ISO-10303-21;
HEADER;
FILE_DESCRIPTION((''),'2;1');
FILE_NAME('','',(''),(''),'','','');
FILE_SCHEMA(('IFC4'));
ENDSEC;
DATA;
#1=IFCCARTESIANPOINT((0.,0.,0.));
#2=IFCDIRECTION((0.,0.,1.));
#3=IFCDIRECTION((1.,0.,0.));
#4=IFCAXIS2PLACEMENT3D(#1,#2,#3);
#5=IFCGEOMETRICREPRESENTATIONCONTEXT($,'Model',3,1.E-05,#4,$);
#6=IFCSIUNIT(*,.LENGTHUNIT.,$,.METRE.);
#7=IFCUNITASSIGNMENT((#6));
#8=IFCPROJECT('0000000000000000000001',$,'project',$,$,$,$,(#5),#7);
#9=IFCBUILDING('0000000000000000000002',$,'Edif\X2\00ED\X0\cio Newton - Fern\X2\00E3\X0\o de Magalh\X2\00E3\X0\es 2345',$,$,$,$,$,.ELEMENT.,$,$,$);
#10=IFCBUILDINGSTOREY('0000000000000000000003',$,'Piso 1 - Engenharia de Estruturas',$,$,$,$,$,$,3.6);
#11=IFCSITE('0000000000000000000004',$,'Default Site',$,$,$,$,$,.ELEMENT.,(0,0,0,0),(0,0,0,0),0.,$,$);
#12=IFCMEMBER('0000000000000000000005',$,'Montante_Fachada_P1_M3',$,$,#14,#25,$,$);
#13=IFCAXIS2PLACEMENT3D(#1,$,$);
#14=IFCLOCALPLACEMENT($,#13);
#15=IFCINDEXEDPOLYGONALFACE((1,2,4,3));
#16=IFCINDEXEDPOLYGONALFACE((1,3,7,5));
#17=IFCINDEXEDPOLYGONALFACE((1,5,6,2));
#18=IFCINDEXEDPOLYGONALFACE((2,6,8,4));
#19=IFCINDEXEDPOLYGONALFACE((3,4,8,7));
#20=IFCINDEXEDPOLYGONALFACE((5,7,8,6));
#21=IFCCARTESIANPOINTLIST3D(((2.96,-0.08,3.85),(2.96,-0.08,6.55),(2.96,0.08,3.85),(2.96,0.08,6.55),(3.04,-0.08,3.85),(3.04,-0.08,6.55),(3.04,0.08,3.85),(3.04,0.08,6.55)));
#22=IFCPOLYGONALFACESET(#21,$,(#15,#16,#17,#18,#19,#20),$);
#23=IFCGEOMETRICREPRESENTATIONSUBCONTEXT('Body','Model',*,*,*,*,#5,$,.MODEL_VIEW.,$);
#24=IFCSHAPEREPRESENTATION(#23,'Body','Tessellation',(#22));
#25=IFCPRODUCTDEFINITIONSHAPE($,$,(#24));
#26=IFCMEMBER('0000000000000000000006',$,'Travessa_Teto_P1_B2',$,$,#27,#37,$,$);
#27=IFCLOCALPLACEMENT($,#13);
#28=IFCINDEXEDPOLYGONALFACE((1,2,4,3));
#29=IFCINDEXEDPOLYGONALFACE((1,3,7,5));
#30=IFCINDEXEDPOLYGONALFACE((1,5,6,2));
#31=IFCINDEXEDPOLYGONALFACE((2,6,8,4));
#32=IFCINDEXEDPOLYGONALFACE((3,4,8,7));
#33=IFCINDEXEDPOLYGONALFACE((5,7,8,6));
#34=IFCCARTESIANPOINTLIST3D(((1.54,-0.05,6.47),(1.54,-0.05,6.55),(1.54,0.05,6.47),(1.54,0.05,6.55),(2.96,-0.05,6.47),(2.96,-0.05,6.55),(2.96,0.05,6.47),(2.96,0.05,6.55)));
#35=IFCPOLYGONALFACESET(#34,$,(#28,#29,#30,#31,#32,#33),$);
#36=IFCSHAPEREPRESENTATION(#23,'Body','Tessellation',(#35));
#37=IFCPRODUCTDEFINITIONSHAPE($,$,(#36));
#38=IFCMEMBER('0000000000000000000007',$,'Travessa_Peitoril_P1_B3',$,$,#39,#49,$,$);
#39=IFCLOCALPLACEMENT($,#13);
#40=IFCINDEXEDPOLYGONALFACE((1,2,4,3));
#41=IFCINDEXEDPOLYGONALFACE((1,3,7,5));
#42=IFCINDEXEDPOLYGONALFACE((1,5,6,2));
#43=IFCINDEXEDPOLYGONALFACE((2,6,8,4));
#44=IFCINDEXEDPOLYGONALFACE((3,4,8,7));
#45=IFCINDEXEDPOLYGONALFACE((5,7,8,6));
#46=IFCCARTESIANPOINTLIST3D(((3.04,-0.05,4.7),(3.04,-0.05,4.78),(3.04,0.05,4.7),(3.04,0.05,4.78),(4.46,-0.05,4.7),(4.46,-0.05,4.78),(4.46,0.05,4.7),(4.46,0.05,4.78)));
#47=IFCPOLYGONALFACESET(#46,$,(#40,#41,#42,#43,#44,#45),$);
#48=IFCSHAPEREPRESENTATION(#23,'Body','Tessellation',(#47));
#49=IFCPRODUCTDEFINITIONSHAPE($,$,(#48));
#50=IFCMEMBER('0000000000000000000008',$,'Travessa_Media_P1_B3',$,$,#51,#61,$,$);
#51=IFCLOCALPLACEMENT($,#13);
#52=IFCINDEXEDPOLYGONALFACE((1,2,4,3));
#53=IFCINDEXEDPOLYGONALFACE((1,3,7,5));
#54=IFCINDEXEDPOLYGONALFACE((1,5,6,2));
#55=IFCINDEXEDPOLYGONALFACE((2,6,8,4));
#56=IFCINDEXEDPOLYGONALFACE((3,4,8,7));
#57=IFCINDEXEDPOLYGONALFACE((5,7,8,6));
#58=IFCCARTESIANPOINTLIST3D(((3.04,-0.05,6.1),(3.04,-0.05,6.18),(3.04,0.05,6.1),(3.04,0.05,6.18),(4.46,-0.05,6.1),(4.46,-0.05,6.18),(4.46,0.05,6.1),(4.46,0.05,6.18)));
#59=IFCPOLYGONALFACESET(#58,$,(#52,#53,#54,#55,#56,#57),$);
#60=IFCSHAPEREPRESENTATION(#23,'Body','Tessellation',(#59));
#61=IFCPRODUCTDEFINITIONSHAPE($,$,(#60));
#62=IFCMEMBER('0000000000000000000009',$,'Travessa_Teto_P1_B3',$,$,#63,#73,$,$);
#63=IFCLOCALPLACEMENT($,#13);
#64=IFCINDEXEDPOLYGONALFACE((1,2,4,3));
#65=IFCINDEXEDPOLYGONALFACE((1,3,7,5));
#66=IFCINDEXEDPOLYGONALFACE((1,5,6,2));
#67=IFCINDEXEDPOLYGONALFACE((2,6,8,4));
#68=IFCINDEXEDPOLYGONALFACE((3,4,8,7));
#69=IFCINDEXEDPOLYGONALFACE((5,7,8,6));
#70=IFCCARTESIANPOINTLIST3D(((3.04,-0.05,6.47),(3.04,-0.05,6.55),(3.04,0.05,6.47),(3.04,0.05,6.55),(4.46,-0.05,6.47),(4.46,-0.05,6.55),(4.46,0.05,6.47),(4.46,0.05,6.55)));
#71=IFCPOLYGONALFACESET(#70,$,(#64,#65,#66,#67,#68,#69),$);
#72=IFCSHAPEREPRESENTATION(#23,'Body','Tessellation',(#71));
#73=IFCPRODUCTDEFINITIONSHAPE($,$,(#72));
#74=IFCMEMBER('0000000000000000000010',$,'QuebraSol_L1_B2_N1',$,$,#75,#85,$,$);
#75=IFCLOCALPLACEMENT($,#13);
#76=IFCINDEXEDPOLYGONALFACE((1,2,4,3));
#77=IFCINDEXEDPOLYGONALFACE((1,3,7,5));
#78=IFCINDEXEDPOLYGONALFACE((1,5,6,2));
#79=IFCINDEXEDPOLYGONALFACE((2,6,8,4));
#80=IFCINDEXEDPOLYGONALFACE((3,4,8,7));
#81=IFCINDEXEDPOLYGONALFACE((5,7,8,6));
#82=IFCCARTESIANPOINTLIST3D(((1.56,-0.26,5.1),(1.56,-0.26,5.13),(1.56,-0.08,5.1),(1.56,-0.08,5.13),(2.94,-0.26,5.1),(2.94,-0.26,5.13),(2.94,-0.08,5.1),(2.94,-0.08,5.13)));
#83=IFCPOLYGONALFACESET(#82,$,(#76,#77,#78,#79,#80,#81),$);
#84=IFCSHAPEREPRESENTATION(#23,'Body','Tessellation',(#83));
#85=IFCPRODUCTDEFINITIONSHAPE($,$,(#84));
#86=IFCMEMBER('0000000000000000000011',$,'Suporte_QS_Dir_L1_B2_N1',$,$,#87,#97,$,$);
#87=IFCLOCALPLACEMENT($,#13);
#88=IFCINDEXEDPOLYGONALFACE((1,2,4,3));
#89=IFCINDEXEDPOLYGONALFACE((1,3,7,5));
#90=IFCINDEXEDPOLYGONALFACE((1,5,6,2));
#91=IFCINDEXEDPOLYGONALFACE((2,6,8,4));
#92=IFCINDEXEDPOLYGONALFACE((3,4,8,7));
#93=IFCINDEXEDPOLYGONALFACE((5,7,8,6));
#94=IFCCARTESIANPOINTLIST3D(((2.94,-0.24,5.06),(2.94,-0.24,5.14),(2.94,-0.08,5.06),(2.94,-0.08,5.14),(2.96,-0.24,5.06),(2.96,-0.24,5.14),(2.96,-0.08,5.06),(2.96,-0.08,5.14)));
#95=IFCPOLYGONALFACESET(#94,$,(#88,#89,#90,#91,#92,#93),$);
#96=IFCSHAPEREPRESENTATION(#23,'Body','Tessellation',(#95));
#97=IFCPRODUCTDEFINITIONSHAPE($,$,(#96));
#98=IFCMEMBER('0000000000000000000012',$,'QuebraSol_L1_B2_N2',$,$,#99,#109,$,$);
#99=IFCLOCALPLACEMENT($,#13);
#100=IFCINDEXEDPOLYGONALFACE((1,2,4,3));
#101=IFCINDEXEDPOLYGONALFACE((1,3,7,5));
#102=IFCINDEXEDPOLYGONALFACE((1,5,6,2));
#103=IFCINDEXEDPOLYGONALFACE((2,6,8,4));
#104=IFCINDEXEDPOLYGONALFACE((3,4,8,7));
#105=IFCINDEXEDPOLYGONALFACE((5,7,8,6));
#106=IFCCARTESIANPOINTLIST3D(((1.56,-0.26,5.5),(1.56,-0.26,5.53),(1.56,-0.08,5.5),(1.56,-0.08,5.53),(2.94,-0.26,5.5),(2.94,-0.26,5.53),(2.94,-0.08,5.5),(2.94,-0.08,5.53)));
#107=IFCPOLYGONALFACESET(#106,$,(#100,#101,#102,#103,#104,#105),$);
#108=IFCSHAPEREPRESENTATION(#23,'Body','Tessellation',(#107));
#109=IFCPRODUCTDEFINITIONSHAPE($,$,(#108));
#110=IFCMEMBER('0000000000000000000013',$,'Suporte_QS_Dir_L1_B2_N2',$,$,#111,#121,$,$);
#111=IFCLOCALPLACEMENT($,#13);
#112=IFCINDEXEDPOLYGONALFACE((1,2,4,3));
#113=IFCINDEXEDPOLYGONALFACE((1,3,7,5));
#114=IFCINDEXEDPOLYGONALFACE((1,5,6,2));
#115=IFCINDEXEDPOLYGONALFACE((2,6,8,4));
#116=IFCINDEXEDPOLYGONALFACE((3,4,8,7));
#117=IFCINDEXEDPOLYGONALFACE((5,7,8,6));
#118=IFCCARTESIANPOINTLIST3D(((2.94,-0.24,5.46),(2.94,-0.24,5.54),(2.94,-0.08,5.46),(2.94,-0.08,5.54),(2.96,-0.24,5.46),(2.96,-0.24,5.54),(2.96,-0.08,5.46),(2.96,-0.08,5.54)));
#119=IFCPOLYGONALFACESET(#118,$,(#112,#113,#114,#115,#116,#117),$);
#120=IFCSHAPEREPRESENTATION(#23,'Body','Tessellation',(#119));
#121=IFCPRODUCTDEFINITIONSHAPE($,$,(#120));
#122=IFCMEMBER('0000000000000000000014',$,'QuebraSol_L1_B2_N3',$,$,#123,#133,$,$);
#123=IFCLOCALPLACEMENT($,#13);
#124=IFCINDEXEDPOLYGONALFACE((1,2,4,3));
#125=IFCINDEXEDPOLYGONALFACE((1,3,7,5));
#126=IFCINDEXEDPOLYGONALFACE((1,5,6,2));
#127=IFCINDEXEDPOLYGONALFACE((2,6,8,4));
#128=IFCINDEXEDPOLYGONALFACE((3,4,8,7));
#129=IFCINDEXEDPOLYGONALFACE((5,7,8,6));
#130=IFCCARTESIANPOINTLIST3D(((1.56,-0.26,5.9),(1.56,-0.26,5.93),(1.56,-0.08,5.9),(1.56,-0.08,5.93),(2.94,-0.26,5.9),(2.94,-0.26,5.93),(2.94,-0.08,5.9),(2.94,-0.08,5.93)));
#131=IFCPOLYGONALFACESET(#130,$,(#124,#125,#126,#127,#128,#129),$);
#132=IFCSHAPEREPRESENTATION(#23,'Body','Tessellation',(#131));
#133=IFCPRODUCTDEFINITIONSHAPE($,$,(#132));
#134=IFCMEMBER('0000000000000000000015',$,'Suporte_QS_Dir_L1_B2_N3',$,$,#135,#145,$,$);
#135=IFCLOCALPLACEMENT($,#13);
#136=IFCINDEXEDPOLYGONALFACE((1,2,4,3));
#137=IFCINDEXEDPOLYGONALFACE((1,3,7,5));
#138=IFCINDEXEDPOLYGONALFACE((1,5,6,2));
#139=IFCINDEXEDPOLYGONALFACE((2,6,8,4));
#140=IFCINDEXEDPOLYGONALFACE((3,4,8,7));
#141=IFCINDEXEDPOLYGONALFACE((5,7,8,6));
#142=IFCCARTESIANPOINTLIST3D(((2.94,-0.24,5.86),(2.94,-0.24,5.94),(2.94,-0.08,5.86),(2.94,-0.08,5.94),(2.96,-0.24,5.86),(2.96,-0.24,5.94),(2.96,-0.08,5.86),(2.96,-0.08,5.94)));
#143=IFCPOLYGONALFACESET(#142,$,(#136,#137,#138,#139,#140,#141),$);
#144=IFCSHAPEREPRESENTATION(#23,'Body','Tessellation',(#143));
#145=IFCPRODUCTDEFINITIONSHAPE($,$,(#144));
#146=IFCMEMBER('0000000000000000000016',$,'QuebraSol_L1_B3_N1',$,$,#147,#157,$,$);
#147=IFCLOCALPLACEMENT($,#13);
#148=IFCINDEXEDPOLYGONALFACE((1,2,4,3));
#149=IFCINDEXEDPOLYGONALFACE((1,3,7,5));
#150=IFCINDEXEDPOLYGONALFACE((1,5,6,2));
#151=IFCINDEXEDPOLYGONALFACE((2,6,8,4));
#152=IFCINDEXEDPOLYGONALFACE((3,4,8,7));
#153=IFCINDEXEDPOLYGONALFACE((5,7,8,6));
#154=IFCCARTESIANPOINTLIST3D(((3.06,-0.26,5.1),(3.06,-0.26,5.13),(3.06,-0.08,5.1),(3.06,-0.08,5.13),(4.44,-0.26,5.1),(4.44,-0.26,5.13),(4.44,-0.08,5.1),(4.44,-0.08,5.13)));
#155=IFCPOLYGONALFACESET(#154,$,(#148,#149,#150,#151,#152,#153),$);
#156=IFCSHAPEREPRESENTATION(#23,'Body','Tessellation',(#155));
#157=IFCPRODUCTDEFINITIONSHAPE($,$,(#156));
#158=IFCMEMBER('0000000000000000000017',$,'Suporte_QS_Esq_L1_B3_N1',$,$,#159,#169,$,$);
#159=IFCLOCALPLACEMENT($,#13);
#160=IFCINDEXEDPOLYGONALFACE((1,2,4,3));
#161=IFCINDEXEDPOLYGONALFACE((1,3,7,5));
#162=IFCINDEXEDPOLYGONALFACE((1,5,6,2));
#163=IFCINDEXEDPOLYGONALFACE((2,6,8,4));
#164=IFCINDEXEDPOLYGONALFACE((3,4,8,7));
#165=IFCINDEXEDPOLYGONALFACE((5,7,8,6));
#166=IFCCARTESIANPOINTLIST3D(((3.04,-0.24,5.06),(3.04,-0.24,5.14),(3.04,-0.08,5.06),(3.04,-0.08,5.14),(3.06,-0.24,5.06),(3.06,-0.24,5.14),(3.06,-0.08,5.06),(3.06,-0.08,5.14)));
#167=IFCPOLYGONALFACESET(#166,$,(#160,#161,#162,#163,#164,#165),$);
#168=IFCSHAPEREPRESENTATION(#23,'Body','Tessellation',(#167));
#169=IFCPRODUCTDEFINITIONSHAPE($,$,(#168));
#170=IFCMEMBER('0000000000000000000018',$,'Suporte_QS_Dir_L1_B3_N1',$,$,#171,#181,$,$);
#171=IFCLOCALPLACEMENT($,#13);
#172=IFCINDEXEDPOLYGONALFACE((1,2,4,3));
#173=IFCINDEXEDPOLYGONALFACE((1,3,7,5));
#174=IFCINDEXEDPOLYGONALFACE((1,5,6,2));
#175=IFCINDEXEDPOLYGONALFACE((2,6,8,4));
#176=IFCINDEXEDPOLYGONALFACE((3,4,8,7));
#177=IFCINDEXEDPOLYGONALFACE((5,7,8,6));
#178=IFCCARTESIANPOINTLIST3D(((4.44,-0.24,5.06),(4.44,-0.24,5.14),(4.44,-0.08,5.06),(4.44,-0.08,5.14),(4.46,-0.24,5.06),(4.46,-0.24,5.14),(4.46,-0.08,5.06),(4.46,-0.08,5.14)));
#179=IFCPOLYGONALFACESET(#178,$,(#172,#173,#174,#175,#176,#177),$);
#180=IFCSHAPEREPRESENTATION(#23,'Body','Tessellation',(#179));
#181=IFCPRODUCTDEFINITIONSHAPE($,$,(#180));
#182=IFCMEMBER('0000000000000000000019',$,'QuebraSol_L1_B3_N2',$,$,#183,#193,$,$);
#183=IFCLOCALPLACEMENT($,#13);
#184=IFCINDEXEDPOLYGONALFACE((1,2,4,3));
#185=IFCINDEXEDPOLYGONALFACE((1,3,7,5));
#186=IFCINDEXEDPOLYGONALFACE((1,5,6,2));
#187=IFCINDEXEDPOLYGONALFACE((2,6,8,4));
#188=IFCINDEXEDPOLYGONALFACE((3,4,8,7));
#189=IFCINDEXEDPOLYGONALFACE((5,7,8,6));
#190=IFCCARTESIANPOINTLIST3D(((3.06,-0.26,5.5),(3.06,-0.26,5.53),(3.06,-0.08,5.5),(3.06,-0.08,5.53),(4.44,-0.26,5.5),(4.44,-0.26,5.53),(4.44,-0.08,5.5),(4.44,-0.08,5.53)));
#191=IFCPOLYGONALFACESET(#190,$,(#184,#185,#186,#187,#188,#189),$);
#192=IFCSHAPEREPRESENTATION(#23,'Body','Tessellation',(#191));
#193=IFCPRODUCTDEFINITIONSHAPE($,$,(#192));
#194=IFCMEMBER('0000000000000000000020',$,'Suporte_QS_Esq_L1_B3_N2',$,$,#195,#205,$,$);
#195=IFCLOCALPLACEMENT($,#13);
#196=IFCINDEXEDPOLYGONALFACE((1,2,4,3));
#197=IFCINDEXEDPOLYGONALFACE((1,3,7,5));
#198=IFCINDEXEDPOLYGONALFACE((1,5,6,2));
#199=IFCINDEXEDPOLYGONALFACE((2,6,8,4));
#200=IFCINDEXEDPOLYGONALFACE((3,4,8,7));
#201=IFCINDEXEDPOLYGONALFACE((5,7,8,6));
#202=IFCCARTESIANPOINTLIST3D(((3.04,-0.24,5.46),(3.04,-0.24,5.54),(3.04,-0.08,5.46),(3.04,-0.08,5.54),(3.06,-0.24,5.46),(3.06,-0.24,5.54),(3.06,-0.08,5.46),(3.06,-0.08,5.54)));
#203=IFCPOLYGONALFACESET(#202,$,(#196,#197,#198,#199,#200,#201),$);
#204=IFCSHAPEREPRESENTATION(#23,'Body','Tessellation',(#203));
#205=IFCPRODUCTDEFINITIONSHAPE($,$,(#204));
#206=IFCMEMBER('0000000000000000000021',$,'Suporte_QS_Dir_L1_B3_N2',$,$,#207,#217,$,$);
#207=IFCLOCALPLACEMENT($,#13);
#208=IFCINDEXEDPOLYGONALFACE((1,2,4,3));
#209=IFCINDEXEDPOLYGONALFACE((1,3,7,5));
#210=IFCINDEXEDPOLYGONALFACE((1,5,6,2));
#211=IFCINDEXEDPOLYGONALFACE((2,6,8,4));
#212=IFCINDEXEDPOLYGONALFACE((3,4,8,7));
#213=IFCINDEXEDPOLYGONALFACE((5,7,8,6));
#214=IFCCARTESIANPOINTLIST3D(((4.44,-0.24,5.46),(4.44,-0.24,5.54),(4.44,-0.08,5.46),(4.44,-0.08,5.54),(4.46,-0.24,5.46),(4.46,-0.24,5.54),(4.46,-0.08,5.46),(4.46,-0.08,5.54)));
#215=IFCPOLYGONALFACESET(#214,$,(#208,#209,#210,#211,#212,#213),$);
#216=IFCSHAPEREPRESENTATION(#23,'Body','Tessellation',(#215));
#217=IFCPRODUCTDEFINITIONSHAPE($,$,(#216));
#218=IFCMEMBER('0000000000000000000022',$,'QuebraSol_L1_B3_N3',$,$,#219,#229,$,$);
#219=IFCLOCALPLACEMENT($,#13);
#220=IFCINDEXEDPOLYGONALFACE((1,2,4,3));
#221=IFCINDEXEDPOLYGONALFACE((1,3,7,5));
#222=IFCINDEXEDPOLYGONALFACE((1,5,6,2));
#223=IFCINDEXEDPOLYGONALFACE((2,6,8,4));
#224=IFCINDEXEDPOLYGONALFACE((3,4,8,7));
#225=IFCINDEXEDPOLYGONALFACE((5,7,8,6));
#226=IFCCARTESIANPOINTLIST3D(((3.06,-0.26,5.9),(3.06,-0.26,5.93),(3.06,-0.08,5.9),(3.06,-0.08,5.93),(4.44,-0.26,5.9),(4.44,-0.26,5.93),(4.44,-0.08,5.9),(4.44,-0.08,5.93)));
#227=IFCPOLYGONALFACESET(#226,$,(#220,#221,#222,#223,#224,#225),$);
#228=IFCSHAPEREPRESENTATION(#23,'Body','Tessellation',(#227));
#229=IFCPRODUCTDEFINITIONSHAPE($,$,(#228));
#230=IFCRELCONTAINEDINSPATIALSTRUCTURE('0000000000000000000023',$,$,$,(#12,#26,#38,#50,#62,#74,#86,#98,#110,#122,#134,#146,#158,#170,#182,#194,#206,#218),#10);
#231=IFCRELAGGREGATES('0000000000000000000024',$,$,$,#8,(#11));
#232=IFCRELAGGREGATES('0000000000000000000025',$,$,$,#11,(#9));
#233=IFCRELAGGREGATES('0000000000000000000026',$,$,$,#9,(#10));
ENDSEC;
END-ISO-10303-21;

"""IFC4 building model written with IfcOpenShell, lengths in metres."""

from ifc_helpers import new_model, si_unit, frame, frame_2d, origin_with_axes, place, context, subcontext, project, spatial, rectangle, extrude, element, save


model = new_model("IFC4")

# Units and contexts
model_context = context("Model", 3, precision=1e-05, world=origin_with_axes())
body_context = subcontext(model_context, "Body", "Model", "MODEL_VIEW")
ifc_project = project(units=[si_unit("LENGTHUNIT", "METRE")], contexts=[model_context])

# Site, building, storey
site = spatial("IfcSite", under=ifc_project, Name="Default Site", CompositionType="ELEMENT", RefLatitude=(0, 0, 0, 0), RefLongitude=(0, 0, 0, 0), RefElevation=0.0)
building = spatial("IfcBuilding", under=site, Name="Edifício Newton - Fernão de Magalhães 2345", CompositionType="ELEMENT")
storey = spatial("IfcBuildingStorey", under=building, Name="Piso 1 - Engenharia de Estruturas", Elevation=3.6)

# Members
member_1_placement = place(None, frame((2.96, -0.08, 3.85), z_axis=(0.0, 0.0, 1.0), x_axis=(1.0, 0.0, 0.0)))
element("IfcMember", 1, at=member_1_placement, inside=storey, Name="Montante_Fachada_P1_M3", context=body_context, shape_type="SweptSolid", body=[
    extrude(rectangle(XDim=0.08, YDim=0.16, at=frame_2d((0.04, 0.08))), origin_with_axes(), (0.0, 0.0, 1.0), 2.7),
])
for number, where, z_axis, x_axis, name in (
    (2, (1.54, -0.05, 6.47), (0.0, 0.0, 1.0), (1.0, 0.0, 0.0), "Travessa_Teto_P1_B2"),
    (3, (3.04, -0.05, 4.7), (0.0, 0.0, 1.0), (1.0, 0.0, 0.0), "Travessa_Peitoril_P1_B3"),
    (4, (3.04, -0.05, 6.1), (0.0, 0.0, 1.0), (1.0, 0.0, 0.0), "Travessa_Media_P1_B3"),
    (5, (3.04, -0.05, 6.47), (0.0, 0.0, 1.0), (1.0, 0.0, 0.0), "Travessa_Teto_P1_B3"),
):
    element("IfcMember", number, at=place(None, frame(where, z_axis=z_axis, x_axis=x_axis)), inside=storey, Name=name, context=body_context, shape_type="SweptSolid", body=[
        extrude(rectangle(XDim=1.42, YDim=0.1, at=frame_2d((0.71, 0.05))), origin_with_axes(), (0.0, 0.0, 1.0), 0.08),
    ])
member_2_placement = place(None, frame((1.56, -0.26, 5.1), z_axis=(0.0, 0.0, 1.0), x_axis=(1.0, 0.0, 0.0)))
element("IfcMember", 6, at=member_2_placement, inside=storey, Name="QuebraSol_L1_B2_N1", context=body_context, shape_type="SweptSolid", body=[
    extrude(rectangle(XDim=1.38, YDim=0.18, at=frame_2d((0.69, 0.09))), origin_with_axes(), (0.0, 0.0, 1.0), 0.03),
])
member_3_placement = place(None, frame((2.94, -0.24, 5.06), z_axis=(0.0, 0.0, 1.0), x_axis=(1.0, 0.0, 0.0)))
element("IfcMember", 7, at=member_3_placement, inside=storey, Name="Suporte_QS_Dir_L1_B2_N1", context=body_context, shape_type="SweptSolid", body=[
    extrude(rectangle(XDim=0.02, YDim=0.16, at=frame_2d((0.01, 0.08))), origin_with_axes(), (0.0, 0.0, 1.0), 0.08),
])
member_4_placement = place(None, frame((1.56, -0.26, 5.5), z_axis=(0.0, 0.0, 1.0), x_axis=(1.0, 0.0, 0.0)))
element("IfcMember", 8, at=member_4_placement, inside=storey, Name="QuebraSol_L1_B2_N2", context=body_context, shape_type="SweptSolid", body=[
    extrude(rectangle(XDim=1.38, YDim=0.18, at=frame_2d((0.69, 0.09))), origin_with_axes(), (0.0, 0.0, 1.0), 0.03),
])
member_5_placement = place(None, frame((2.94, -0.24, 5.46), z_axis=(0.0, 0.0, 1.0), x_axis=(1.0, 0.0, 0.0)))
element("IfcMember", 9, at=member_5_placement, inside=storey, Name="Suporte_QS_Dir_L1_B2_N2", context=body_context, shape_type="SweptSolid", body=[
    extrude(rectangle(XDim=0.02, YDim=0.16, at=frame_2d((0.01, 0.08))), origin_with_axes(), (0.0, 0.0, 1.0), 0.08),
])
member_6_placement = place(None, frame((1.56, -0.26, 5.9), z_axis=(0.0, 0.0, 1.0), x_axis=(1.0, 0.0, 0.0)))
element("IfcMember", 10, at=member_6_placement, inside=storey, Name="QuebraSol_L1_B2_N3", context=body_context, shape_type="SweptSolid", body=[
    extrude(rectangle(XDim=1.38, YDim=0.18, at=frame_2d((0.69, 0.09))), origin_with_axes(), (0.0, 0.0, 1.0), 0.03),
])
member_7_placement = place(None, frame((2.94, -0.24, 5.86), z_axis=(0.0, 0.0, 1.0), x_axis=(1.0, 0.0, 0.0)))
element("IfcMember", 11, at=member_7_placement, inside=storey, Name="Suporte_QS_Dir_L1_B2_N3", context=body_context, shape_type="SweptSolid", body=[
    extrude(rectangle(XDim=0.02, YDim=0.16, at=frame_2d((0.01, 0.08))), origin_with_axes(), (0.0, 0.0, 1.0), 0.08),
])
member_8_placement = place(None, frame((3.06, -0.26, 5.1), z_axis=(0.0, 0.0, 1.0), x_axis=(1.0, 0.0, 0.0)))
element("IfcMember", 12, at=member_8_placement, inside=storey, Name="QuebraSol_L1_B3_N1", context=body_context, shape_type="SweptSolid", body=[
    extrude(rectangle(XDim=1.38, YDim=0.18, at=frame_2d((0.69, 0.09))), origin_with_axes(), (0.0, 0.0, 1.0), 0.03),
])
for number, where, z_axis, x_axis, name in (
    (13, (3.04, -0.24, 5.06), (0.0, 0.0, 1.0), (1.0, 0.0, 0.0), "Suporte_QS_Esq_L1_B3_N1"),
    (14, (4.44, -0.24, 5.06), (0.0, 0.0, 1.0), (1.0, 0.0, 0.0), "Suporte_QS_Dir_L1_B3_N1"),
):
    element("IfcMember", number, at=place(None, frame(where, z_axis=z_axis, x_axis=x_axis)), inside=storey, Name=name, context=body_context, shape_type="SweptSolid", body=[
        extrude(rectangle(XDim=0.02, YDim=0.16, at=frame_2d((0.01, 0.08))), origin_with_axes(), (0.0, 0.0, 1.0), 0.08),
    ])
member_9_placement = place(None, frame((3.06, -0.26, 5.5), z_axis=(0.0, 0.0, 1.0), x_axis=(1.0, 0.0, 0.0)))
element("IfcMember", 15, at=member_9_placement, inside=storey, Name="QuebraSol_L1_B3_N2", context=body_context, shape_type="SweptSolid", body=[
    extrude(rectangle(XDim=1.38, YDim=0.18, at=frame_2d((0.69, 0.09))), origin_with_axes(), (0.0, 0.0, 1.0), 0.03),
])
for number, where, z_axis, x_axis, name in (
    (16, (3.04, -0.24, 5.46), (0.0, 0.0, 1.0), (1.0, 0.0, 0.0), "Suporte_QS_Esq_L1_B3_N2"),
    (17, (4.44, -0.24, 5.46), (0.0, 0.0, 1.0), (1.0, 0.0, 0.0), "Suporte_QS_Dir_L1_B3_N2"),
):
    element("IfcMember", number, at=place(None, frame(where, z_axis=z_axis, x_axis=x_axis)), inside=storey, Name=name, context=body_context, shape_type="SweptSolid", body=[
        extrude(rectangle(XDim=0.02, YDim=0.16, at=frame_2d((0.01, 0.08))), origin_with_axes(), (0.0, 0.0, 1.0), 0.08),
    ])
member_10_placement = place(None, frame((3.06, -0.26, 5.9), z_axis=(0.0, 0.0, 1.0), x_axis=(1.0, 0.0, 0.0)))
element("IfcMember", 18, at=member_10_placement, inside=storey, Name="QuebraSol_L1_B3_N3", context=body_context, shape_type="SweptSolid", body=[
    extrude(rectangle(XDim=1.38, YDim=0.18, at=frame_2d((0.69, 0.09))), origin_with_axes(), (0.0, 0.0, 1.0), 0.03),
])

save(model, "model.ifc")
